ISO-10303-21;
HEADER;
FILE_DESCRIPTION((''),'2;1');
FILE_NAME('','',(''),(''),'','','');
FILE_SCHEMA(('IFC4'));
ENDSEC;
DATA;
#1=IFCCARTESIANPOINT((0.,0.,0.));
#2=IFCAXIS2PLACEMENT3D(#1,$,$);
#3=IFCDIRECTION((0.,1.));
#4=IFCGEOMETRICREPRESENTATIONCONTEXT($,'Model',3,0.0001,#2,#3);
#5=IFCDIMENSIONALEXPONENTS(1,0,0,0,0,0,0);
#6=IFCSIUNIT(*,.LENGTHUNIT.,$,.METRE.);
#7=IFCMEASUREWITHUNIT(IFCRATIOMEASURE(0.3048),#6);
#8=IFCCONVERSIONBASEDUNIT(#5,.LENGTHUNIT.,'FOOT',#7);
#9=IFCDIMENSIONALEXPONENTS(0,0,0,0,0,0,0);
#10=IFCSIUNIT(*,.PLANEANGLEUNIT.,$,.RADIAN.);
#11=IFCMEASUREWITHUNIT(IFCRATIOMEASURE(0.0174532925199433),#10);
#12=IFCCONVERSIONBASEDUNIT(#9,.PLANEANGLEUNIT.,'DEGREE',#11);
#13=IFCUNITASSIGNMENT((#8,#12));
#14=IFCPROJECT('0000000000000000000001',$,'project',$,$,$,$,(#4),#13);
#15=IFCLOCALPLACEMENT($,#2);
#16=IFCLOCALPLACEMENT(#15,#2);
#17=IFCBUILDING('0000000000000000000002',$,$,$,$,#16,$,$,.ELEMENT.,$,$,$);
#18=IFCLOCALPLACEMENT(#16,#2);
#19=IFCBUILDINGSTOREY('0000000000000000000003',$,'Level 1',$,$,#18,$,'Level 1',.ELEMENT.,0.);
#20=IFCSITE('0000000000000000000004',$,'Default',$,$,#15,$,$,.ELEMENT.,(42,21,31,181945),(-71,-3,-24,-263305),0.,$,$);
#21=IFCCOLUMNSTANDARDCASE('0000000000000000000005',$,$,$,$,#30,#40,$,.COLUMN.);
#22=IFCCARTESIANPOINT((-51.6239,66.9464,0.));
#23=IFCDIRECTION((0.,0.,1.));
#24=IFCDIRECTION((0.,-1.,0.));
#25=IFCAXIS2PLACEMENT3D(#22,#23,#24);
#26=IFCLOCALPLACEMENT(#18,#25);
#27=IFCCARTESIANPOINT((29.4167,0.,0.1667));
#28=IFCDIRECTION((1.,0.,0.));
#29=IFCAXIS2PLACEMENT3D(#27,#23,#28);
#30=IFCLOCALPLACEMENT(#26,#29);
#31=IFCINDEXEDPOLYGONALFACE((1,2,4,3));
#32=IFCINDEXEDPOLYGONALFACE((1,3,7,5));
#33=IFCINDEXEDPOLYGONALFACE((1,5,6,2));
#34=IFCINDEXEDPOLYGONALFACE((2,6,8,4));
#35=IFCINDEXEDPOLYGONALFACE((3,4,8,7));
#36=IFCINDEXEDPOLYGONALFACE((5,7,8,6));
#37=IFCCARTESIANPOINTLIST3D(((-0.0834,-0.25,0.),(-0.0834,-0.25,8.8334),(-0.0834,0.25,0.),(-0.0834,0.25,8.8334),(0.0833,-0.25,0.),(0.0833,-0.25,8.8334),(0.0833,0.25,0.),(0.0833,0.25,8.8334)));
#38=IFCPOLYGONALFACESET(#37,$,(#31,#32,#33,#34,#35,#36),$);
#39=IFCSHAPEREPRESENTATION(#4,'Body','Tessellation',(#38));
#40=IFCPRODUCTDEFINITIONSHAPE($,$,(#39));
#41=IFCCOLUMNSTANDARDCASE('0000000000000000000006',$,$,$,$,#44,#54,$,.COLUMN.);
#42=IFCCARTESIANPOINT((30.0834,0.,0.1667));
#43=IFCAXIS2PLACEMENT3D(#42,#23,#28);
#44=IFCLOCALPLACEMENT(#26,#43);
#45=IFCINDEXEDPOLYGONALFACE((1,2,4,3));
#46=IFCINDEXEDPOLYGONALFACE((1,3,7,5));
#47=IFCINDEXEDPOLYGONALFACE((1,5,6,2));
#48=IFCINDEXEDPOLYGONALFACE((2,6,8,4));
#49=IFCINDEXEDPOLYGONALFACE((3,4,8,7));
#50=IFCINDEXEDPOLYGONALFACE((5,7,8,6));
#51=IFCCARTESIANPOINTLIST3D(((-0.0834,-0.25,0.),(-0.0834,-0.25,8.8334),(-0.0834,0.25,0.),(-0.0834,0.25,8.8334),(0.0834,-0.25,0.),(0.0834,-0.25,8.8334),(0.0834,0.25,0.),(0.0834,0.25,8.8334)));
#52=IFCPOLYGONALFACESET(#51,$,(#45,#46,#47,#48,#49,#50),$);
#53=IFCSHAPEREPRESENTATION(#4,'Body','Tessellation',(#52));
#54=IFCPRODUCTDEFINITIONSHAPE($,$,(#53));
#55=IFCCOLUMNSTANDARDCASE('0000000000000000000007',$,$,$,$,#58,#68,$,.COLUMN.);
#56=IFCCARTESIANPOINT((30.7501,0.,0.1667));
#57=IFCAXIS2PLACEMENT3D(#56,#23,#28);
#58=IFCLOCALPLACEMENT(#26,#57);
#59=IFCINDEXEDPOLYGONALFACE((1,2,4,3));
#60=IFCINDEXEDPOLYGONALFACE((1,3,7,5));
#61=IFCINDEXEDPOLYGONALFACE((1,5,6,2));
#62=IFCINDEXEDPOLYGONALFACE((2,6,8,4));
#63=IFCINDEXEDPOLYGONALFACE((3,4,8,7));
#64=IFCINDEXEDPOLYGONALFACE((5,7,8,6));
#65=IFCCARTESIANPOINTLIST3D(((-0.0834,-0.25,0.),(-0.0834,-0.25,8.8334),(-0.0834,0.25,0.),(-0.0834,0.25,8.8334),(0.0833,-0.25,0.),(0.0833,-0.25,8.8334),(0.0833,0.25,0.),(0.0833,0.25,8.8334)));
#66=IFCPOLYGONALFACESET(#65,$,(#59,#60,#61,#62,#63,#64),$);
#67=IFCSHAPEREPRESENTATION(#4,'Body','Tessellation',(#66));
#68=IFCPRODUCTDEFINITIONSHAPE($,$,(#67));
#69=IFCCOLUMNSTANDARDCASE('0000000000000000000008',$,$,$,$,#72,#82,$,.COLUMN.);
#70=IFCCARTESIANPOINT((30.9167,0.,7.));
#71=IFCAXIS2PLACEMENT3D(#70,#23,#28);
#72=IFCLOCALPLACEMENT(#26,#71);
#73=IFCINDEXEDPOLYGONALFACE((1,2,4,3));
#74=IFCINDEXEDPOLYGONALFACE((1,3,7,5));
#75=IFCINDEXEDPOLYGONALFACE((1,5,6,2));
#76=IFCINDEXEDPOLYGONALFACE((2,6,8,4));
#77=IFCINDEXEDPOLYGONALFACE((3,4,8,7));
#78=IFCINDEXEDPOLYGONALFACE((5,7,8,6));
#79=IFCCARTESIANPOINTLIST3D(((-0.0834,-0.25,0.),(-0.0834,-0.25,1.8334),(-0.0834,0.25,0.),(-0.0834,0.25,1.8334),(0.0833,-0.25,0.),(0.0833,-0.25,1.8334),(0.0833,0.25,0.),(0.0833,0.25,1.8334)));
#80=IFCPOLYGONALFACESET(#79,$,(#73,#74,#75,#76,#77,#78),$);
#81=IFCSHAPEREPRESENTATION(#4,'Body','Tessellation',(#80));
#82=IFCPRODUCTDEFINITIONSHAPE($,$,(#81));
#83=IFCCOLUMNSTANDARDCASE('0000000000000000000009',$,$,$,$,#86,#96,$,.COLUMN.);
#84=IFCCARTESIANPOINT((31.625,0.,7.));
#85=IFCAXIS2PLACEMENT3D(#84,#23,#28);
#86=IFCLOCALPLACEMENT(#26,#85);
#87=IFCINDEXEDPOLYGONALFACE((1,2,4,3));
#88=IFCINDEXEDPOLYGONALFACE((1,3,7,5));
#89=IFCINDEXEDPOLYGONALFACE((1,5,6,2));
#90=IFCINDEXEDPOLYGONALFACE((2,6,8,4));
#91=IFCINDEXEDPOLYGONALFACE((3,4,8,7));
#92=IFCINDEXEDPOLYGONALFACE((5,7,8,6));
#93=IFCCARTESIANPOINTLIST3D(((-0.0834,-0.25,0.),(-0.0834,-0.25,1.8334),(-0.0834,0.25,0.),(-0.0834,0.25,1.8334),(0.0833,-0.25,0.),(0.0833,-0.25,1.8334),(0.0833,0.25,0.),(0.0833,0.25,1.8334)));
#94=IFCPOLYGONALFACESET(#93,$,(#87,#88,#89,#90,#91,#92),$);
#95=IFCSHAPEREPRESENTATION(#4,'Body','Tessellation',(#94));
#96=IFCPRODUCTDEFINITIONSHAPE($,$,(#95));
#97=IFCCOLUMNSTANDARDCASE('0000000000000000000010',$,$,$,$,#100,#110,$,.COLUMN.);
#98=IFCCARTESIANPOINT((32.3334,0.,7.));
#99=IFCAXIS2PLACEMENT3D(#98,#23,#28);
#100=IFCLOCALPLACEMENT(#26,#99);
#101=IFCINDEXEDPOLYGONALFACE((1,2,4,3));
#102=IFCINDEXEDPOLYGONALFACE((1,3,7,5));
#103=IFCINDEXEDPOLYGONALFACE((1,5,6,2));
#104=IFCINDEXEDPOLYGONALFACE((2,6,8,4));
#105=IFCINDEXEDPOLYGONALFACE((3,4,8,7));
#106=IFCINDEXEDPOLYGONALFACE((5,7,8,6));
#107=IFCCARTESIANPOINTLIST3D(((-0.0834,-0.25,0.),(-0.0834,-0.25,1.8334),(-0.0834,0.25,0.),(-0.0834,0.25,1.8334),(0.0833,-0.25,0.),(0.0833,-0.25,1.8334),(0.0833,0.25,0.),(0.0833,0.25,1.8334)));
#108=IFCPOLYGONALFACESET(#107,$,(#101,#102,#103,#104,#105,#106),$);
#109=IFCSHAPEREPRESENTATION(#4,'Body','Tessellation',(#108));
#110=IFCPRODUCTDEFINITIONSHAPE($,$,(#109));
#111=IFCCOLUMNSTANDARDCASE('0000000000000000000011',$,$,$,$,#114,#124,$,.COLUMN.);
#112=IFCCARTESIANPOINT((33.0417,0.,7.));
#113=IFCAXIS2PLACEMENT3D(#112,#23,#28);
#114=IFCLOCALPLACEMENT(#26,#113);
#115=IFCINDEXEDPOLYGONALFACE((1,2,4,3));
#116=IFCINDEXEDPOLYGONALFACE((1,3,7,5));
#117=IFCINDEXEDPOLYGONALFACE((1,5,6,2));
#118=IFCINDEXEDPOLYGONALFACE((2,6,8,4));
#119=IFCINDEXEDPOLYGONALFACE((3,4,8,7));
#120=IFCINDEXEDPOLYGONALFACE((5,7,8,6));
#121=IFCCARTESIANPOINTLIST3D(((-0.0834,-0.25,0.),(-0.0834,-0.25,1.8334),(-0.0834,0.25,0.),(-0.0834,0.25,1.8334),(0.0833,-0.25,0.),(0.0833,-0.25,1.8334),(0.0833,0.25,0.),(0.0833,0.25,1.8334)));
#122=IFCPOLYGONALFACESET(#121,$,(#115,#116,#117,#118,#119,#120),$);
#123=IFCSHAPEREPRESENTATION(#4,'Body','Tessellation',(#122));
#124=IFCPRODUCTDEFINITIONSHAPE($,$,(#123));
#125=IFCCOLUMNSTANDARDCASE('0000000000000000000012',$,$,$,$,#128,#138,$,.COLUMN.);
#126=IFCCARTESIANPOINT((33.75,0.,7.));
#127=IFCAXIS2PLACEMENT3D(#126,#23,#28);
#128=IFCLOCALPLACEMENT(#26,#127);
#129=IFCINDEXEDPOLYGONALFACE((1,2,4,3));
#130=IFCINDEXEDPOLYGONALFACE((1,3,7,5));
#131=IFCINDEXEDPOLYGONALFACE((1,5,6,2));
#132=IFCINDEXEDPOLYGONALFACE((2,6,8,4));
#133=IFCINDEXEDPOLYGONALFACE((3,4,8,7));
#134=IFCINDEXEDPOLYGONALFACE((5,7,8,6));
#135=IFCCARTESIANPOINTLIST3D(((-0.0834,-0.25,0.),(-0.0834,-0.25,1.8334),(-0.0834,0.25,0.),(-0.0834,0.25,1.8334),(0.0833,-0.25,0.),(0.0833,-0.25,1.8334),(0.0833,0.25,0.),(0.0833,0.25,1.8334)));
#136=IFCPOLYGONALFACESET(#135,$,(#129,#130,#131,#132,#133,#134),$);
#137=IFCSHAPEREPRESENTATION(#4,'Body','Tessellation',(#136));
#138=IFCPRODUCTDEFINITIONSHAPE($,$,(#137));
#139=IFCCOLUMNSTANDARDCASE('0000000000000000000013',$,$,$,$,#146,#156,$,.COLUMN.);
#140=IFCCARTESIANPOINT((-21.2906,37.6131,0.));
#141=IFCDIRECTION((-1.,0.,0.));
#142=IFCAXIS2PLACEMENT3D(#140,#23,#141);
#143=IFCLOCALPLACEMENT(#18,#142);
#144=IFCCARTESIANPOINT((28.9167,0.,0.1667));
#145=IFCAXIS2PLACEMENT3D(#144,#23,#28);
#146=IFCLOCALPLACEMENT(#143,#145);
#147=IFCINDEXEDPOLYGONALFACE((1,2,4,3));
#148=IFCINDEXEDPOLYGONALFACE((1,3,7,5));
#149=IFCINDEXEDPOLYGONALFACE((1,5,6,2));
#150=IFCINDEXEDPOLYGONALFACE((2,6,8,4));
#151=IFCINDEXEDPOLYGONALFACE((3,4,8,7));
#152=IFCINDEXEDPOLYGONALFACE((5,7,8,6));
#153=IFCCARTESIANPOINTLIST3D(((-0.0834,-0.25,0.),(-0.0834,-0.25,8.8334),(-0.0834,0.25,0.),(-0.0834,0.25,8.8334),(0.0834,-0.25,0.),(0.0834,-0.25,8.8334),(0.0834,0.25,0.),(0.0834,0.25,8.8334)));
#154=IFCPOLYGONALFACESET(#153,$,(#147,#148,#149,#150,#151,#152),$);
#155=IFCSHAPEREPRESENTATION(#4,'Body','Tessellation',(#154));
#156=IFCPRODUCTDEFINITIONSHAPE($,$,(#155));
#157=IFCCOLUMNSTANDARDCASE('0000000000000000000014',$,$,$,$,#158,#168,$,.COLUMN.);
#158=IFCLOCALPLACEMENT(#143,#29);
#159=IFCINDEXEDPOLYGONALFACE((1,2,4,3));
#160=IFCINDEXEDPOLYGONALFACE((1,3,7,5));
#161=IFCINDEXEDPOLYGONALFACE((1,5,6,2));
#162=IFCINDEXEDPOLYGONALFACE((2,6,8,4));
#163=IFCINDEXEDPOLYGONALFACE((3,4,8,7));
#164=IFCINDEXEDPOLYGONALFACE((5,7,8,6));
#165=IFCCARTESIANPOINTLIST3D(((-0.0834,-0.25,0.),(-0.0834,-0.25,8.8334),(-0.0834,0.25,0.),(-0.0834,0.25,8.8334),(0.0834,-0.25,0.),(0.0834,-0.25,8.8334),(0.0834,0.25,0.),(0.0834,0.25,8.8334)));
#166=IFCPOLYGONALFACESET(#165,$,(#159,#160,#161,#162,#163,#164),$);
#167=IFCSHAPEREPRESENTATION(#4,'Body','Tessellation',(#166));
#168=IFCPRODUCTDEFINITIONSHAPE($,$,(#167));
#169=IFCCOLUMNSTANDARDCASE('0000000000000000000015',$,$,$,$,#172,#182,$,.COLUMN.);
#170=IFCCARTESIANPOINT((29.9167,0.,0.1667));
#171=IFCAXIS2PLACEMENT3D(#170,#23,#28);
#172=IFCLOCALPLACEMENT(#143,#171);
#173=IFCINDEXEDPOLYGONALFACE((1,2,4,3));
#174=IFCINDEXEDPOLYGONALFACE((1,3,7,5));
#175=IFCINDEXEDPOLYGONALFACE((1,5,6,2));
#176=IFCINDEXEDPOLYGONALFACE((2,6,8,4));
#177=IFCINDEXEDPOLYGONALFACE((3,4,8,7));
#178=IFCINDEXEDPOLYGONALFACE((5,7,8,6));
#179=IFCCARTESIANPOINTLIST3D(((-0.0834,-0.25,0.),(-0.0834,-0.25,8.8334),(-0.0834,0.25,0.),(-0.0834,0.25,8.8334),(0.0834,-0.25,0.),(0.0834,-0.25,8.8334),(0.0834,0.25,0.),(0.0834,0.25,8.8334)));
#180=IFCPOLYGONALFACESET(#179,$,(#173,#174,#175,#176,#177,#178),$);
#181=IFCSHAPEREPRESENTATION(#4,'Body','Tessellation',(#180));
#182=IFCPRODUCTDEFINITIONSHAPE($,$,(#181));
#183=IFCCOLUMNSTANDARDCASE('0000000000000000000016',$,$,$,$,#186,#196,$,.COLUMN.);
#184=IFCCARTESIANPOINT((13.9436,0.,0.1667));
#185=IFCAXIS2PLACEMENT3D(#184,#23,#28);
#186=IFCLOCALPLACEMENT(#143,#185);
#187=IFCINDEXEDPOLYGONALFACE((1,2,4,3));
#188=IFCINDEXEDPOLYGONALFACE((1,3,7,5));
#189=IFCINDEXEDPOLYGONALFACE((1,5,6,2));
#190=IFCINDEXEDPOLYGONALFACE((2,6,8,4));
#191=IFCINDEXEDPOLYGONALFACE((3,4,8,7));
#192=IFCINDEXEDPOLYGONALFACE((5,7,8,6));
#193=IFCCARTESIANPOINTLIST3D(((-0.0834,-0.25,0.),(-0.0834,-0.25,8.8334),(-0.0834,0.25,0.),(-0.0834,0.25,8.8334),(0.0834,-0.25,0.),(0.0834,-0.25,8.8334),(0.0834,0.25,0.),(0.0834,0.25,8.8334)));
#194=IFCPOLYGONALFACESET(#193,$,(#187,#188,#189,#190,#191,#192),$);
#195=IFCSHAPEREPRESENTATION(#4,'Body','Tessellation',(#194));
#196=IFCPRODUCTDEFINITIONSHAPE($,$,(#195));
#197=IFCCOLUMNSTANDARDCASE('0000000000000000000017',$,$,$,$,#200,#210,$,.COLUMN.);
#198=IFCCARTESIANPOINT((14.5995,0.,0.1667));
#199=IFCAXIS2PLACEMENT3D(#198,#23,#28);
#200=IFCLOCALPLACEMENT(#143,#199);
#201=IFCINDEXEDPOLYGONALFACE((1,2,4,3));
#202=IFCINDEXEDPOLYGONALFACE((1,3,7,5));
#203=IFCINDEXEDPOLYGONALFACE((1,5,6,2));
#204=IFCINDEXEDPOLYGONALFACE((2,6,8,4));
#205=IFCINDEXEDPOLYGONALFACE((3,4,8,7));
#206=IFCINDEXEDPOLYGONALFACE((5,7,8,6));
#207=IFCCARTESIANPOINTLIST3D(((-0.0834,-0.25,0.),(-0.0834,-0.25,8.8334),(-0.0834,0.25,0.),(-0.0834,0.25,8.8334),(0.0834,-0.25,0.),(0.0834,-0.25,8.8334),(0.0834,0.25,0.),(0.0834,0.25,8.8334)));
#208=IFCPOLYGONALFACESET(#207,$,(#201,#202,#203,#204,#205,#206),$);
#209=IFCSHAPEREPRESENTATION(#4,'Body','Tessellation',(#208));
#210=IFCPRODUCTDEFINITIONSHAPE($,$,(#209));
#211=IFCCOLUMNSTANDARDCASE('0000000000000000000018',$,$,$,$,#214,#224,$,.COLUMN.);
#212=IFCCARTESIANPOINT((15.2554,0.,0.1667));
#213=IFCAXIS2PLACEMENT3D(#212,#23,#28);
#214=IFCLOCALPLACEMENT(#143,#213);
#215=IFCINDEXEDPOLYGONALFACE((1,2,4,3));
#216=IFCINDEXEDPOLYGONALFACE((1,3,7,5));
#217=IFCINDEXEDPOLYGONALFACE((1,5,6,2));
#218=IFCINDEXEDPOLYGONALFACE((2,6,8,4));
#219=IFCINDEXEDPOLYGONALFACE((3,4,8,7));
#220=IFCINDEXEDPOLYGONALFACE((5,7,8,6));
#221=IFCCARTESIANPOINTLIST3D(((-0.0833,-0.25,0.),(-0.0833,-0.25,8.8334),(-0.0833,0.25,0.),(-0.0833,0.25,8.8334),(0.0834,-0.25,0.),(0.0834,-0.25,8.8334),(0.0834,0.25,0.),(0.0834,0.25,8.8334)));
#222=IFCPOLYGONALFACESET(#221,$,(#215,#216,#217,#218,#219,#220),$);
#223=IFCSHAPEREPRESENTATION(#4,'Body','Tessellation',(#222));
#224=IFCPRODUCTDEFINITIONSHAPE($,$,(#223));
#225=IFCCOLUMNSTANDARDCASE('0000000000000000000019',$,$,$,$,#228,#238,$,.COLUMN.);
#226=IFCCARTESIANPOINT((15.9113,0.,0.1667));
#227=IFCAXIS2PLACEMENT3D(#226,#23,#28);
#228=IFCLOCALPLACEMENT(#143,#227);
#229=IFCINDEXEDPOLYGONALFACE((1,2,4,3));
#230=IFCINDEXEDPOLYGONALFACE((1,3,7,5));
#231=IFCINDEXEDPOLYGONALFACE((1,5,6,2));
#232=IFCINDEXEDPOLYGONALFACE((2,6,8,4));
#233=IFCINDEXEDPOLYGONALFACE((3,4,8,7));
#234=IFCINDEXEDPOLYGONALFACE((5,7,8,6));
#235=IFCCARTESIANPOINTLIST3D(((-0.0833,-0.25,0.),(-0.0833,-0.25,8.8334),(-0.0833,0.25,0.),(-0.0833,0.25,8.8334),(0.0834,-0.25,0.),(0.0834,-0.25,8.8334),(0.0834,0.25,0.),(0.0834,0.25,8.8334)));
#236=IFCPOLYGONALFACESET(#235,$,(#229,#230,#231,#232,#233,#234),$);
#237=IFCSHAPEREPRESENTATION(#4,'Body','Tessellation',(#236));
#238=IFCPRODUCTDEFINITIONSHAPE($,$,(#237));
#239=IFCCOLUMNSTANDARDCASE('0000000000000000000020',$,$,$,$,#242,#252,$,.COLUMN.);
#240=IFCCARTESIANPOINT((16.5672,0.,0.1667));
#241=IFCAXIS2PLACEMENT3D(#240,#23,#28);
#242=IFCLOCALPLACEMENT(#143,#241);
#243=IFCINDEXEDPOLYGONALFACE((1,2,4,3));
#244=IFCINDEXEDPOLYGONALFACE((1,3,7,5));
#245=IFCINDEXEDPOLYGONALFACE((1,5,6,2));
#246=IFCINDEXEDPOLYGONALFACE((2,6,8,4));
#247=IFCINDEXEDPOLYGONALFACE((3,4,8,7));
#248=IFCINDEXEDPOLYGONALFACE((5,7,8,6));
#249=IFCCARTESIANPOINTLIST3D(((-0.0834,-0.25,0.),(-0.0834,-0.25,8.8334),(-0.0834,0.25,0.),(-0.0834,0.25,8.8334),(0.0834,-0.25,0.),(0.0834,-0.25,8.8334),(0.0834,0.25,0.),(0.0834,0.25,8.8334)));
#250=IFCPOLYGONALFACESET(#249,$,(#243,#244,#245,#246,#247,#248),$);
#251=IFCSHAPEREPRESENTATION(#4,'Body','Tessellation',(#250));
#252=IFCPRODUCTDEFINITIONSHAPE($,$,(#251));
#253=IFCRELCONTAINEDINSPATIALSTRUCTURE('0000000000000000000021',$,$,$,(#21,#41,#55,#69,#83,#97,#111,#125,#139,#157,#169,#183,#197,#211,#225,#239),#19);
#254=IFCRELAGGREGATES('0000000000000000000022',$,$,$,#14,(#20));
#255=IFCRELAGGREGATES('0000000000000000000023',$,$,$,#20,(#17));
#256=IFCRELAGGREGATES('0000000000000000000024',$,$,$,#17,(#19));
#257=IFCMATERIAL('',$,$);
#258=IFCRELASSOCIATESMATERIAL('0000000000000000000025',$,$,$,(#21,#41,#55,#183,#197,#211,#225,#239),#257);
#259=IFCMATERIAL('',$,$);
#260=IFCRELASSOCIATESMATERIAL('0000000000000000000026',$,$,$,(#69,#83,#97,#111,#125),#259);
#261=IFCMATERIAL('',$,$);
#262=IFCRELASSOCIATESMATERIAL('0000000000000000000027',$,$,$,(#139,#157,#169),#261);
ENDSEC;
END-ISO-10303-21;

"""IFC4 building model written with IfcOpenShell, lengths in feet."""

from ifc_helpers import new_model, entity, si_unit, converted_unit, direction, frame, origin, place, context, project, spatial, rectangle, extrude, material, element, save


model = new_model("IFC4")

# Units and contexts
model_context = context("Model", 3, precision=0.0001, world=origin(), true_north=direction((0.0, 1.0)))
ifc_project = project(units=[converted_unit("LENGTHUNIT", "FOOT", entity("IfcRatioMeasure", 0.3048), si_unit("LENGTHUNIT", "METRE"), dimensions=[1, 0, 0, 0, 0, 0, 0]), converted_unit("PLANEANGLEUNIT", "DEGREE", entity("IfcRatioMeasure", 0.0174532925199433), si_unit("PLANEANGLEUNIT", "RADIAN"), dimensions=[0, 0, 0, 0, 0, 0, 0])], contexts=[model_context])

# Site, building, storey
site_placement = place(None, origin())
site = spatial("IfcSite", under=ifc_project, at=site_placement, Name="Default", CompositionType="ELEMENT", RefLatitude=(42, 21, 31, 181945), RefLongitude=(-71, -3, -24, -263305), RefElevation=0.0)
building_placement = place(site_placement, origin())
building = spatial("IfcBuilding", under=site, at=building_placement, CompositionType="ELEMENT")
storey_placement = place(building_placement, origin())
storey = spatial("IfcBuildingStorey", under=building, at=storey_placement, Name="Level 1", LongName="Level 1", CompositionType="ELEMENT", Elevation=0.0)

# Columns
ifc_material_1 = material(Name="")
placement_1 = place(storey_placement, frame((-51.6239, 66.9464, 0.0), z_axis=(0.0, 0.0, 1.0), x_axis=(0.0, -1.0, 0.0)))
for number, where, z_axis, x_axis in (
    (1, (29.4167, 0.0, 0.1667), (0.0, 0.0, 1.0), (1.0, 0.0, 0.0)),
    (2, (30.0834, 0.0, 0.1667), (0.0, 0.0, 1.0), (1.0, 0.0, 0.0)),
    (3, (30.7501, 0.0, 0.1667), (0.0, 0.0, 1.0), (1.0, 0.0, 0.0)),
):
    element("IfcColumnStandardCase", number, at=place(placement_1, frame(where, z_axis=z_axis, x_axis=x_axis)), inside=storey, material=ifc_material_1, PredefinedType="COLUMN", context=model_context, shape_type="SweptSolid", body=[
        extrude(rectangle(XDim=0.1667, YDim=0.5), origin(), (0.0, 0.0, 1.0), 8.8334),
    ])
ifc_material_2 = material(Name="")
for number, where, z_axis, x_axis in (
    (4, (30.9167, 0.0, 7.0), (0.0, 0.0, 1.0), (1.0, 0.0, 0.0)),
    (5, (31.625, 0.0, 7.0), (0.0, 0.0, 1.0), (1.0, 0.0, 0.0)),
    (6, (32.3334, 0.0, 7.0), (0.0, 0.0, 1.0), (1.0, 0.0, 0.0)),
    (7, (33.0417, 0.0, 7.0), (0.0, 0.0, 1.0), (1.0, 0.0, 0.0)),
    (8, (33.75, 0.0, 7.0), (0.0, 0.0, 1.0), (1.0, 0.0, 0.0)),
):
    element("IfcColumnStandardCase", number, at=place(placement_1, frame(where, z_axis=z_axis, x_axis=x_axis)), inside=storey, material=ifc_material_2, PredefinedType="COLUMN", context=model_context, shape_type="SweptSolid", body=[
        extrude(rectangle(XDim=0.1667, YDim=0.5), origin(), (0.0, 0.0, 1.0), 1.8334),
    ])
ifc_material_3 = material(Name="")
placement_2 = place(storey_placement, frame((-21.2906, 37.6131, 0.0), z_axis=(0.0, 0.0, 1.0), x_axis=(-1.0, 0.0, 0.0)))
for number, where, z_axis, x_axis in (
    (9, (28.9167, 0.0, 0.1667), (0.0, 0.0, 1.0), (1.0, 0.0, 0.0)),
    (10, (29.4167, 0.0, 0.1667), (0.0, 0.0, 1.0), (1.0, 0.0, 0.0)),
    (11, (29.9167, 0.0, 0.1667), (0.0, 0.0, 1.0), (1.0, 0.0, 0.0)),
):
    element("IfcColumnStandardCase", number, at=place(placement_2, frame(where, z_axis=z_axis, x_axis=x_axis)), inside=storey, material=ifc_material_3, PredefinedType="COLUMN", context=model_context, shape_type="SweptSolid", body=[
        extrude(rectangle(XDim=0.1667, YDim=0.5), origin(), (0.0, 0.0, 1.0), 8.8334),
    ])
for number, where, z_axis, x_axis in (
    (12, (13.9436, 0.0, 0.1667), (0.0, 0.0, 1.0), (1.0, 0.0, 0.0)),
    (13, (14.5995, 0.0, 0.1667), (0.0, 0.0, 1.0), (1.0, 0.0, 0.0)),
    (14, (15.2554, 0.0, 0.1667), (0.0, 0.0, 1.0), (1.0, 0.0, 0.0)),
    (15, (15.9113, 0.0, 0.1667), (0.0, 0.0, 1.0), (1.0, 0.0, 0.0)),
    (16, (16.5672, 0.0, 0.1667), (0.0, 0.0, 1.0), (1.0, 0.0, 0.0)),
):
    element("IfcColumnStandardCase", number, at=place(placement_2, frame(where, z_axis=z_axis, x_axis=x_axis)), inside=storey, material=ifc_material_1, PredefinedType="COLUMN", context=model_context, shape_type="SweptSolid", body=[
        extrude(rectangle(XDim=0.1667, YDim=0.5), origin(), (0.0, 0.0, 1.0), 8.8334),
    ])

save(model, "model.ifc")
